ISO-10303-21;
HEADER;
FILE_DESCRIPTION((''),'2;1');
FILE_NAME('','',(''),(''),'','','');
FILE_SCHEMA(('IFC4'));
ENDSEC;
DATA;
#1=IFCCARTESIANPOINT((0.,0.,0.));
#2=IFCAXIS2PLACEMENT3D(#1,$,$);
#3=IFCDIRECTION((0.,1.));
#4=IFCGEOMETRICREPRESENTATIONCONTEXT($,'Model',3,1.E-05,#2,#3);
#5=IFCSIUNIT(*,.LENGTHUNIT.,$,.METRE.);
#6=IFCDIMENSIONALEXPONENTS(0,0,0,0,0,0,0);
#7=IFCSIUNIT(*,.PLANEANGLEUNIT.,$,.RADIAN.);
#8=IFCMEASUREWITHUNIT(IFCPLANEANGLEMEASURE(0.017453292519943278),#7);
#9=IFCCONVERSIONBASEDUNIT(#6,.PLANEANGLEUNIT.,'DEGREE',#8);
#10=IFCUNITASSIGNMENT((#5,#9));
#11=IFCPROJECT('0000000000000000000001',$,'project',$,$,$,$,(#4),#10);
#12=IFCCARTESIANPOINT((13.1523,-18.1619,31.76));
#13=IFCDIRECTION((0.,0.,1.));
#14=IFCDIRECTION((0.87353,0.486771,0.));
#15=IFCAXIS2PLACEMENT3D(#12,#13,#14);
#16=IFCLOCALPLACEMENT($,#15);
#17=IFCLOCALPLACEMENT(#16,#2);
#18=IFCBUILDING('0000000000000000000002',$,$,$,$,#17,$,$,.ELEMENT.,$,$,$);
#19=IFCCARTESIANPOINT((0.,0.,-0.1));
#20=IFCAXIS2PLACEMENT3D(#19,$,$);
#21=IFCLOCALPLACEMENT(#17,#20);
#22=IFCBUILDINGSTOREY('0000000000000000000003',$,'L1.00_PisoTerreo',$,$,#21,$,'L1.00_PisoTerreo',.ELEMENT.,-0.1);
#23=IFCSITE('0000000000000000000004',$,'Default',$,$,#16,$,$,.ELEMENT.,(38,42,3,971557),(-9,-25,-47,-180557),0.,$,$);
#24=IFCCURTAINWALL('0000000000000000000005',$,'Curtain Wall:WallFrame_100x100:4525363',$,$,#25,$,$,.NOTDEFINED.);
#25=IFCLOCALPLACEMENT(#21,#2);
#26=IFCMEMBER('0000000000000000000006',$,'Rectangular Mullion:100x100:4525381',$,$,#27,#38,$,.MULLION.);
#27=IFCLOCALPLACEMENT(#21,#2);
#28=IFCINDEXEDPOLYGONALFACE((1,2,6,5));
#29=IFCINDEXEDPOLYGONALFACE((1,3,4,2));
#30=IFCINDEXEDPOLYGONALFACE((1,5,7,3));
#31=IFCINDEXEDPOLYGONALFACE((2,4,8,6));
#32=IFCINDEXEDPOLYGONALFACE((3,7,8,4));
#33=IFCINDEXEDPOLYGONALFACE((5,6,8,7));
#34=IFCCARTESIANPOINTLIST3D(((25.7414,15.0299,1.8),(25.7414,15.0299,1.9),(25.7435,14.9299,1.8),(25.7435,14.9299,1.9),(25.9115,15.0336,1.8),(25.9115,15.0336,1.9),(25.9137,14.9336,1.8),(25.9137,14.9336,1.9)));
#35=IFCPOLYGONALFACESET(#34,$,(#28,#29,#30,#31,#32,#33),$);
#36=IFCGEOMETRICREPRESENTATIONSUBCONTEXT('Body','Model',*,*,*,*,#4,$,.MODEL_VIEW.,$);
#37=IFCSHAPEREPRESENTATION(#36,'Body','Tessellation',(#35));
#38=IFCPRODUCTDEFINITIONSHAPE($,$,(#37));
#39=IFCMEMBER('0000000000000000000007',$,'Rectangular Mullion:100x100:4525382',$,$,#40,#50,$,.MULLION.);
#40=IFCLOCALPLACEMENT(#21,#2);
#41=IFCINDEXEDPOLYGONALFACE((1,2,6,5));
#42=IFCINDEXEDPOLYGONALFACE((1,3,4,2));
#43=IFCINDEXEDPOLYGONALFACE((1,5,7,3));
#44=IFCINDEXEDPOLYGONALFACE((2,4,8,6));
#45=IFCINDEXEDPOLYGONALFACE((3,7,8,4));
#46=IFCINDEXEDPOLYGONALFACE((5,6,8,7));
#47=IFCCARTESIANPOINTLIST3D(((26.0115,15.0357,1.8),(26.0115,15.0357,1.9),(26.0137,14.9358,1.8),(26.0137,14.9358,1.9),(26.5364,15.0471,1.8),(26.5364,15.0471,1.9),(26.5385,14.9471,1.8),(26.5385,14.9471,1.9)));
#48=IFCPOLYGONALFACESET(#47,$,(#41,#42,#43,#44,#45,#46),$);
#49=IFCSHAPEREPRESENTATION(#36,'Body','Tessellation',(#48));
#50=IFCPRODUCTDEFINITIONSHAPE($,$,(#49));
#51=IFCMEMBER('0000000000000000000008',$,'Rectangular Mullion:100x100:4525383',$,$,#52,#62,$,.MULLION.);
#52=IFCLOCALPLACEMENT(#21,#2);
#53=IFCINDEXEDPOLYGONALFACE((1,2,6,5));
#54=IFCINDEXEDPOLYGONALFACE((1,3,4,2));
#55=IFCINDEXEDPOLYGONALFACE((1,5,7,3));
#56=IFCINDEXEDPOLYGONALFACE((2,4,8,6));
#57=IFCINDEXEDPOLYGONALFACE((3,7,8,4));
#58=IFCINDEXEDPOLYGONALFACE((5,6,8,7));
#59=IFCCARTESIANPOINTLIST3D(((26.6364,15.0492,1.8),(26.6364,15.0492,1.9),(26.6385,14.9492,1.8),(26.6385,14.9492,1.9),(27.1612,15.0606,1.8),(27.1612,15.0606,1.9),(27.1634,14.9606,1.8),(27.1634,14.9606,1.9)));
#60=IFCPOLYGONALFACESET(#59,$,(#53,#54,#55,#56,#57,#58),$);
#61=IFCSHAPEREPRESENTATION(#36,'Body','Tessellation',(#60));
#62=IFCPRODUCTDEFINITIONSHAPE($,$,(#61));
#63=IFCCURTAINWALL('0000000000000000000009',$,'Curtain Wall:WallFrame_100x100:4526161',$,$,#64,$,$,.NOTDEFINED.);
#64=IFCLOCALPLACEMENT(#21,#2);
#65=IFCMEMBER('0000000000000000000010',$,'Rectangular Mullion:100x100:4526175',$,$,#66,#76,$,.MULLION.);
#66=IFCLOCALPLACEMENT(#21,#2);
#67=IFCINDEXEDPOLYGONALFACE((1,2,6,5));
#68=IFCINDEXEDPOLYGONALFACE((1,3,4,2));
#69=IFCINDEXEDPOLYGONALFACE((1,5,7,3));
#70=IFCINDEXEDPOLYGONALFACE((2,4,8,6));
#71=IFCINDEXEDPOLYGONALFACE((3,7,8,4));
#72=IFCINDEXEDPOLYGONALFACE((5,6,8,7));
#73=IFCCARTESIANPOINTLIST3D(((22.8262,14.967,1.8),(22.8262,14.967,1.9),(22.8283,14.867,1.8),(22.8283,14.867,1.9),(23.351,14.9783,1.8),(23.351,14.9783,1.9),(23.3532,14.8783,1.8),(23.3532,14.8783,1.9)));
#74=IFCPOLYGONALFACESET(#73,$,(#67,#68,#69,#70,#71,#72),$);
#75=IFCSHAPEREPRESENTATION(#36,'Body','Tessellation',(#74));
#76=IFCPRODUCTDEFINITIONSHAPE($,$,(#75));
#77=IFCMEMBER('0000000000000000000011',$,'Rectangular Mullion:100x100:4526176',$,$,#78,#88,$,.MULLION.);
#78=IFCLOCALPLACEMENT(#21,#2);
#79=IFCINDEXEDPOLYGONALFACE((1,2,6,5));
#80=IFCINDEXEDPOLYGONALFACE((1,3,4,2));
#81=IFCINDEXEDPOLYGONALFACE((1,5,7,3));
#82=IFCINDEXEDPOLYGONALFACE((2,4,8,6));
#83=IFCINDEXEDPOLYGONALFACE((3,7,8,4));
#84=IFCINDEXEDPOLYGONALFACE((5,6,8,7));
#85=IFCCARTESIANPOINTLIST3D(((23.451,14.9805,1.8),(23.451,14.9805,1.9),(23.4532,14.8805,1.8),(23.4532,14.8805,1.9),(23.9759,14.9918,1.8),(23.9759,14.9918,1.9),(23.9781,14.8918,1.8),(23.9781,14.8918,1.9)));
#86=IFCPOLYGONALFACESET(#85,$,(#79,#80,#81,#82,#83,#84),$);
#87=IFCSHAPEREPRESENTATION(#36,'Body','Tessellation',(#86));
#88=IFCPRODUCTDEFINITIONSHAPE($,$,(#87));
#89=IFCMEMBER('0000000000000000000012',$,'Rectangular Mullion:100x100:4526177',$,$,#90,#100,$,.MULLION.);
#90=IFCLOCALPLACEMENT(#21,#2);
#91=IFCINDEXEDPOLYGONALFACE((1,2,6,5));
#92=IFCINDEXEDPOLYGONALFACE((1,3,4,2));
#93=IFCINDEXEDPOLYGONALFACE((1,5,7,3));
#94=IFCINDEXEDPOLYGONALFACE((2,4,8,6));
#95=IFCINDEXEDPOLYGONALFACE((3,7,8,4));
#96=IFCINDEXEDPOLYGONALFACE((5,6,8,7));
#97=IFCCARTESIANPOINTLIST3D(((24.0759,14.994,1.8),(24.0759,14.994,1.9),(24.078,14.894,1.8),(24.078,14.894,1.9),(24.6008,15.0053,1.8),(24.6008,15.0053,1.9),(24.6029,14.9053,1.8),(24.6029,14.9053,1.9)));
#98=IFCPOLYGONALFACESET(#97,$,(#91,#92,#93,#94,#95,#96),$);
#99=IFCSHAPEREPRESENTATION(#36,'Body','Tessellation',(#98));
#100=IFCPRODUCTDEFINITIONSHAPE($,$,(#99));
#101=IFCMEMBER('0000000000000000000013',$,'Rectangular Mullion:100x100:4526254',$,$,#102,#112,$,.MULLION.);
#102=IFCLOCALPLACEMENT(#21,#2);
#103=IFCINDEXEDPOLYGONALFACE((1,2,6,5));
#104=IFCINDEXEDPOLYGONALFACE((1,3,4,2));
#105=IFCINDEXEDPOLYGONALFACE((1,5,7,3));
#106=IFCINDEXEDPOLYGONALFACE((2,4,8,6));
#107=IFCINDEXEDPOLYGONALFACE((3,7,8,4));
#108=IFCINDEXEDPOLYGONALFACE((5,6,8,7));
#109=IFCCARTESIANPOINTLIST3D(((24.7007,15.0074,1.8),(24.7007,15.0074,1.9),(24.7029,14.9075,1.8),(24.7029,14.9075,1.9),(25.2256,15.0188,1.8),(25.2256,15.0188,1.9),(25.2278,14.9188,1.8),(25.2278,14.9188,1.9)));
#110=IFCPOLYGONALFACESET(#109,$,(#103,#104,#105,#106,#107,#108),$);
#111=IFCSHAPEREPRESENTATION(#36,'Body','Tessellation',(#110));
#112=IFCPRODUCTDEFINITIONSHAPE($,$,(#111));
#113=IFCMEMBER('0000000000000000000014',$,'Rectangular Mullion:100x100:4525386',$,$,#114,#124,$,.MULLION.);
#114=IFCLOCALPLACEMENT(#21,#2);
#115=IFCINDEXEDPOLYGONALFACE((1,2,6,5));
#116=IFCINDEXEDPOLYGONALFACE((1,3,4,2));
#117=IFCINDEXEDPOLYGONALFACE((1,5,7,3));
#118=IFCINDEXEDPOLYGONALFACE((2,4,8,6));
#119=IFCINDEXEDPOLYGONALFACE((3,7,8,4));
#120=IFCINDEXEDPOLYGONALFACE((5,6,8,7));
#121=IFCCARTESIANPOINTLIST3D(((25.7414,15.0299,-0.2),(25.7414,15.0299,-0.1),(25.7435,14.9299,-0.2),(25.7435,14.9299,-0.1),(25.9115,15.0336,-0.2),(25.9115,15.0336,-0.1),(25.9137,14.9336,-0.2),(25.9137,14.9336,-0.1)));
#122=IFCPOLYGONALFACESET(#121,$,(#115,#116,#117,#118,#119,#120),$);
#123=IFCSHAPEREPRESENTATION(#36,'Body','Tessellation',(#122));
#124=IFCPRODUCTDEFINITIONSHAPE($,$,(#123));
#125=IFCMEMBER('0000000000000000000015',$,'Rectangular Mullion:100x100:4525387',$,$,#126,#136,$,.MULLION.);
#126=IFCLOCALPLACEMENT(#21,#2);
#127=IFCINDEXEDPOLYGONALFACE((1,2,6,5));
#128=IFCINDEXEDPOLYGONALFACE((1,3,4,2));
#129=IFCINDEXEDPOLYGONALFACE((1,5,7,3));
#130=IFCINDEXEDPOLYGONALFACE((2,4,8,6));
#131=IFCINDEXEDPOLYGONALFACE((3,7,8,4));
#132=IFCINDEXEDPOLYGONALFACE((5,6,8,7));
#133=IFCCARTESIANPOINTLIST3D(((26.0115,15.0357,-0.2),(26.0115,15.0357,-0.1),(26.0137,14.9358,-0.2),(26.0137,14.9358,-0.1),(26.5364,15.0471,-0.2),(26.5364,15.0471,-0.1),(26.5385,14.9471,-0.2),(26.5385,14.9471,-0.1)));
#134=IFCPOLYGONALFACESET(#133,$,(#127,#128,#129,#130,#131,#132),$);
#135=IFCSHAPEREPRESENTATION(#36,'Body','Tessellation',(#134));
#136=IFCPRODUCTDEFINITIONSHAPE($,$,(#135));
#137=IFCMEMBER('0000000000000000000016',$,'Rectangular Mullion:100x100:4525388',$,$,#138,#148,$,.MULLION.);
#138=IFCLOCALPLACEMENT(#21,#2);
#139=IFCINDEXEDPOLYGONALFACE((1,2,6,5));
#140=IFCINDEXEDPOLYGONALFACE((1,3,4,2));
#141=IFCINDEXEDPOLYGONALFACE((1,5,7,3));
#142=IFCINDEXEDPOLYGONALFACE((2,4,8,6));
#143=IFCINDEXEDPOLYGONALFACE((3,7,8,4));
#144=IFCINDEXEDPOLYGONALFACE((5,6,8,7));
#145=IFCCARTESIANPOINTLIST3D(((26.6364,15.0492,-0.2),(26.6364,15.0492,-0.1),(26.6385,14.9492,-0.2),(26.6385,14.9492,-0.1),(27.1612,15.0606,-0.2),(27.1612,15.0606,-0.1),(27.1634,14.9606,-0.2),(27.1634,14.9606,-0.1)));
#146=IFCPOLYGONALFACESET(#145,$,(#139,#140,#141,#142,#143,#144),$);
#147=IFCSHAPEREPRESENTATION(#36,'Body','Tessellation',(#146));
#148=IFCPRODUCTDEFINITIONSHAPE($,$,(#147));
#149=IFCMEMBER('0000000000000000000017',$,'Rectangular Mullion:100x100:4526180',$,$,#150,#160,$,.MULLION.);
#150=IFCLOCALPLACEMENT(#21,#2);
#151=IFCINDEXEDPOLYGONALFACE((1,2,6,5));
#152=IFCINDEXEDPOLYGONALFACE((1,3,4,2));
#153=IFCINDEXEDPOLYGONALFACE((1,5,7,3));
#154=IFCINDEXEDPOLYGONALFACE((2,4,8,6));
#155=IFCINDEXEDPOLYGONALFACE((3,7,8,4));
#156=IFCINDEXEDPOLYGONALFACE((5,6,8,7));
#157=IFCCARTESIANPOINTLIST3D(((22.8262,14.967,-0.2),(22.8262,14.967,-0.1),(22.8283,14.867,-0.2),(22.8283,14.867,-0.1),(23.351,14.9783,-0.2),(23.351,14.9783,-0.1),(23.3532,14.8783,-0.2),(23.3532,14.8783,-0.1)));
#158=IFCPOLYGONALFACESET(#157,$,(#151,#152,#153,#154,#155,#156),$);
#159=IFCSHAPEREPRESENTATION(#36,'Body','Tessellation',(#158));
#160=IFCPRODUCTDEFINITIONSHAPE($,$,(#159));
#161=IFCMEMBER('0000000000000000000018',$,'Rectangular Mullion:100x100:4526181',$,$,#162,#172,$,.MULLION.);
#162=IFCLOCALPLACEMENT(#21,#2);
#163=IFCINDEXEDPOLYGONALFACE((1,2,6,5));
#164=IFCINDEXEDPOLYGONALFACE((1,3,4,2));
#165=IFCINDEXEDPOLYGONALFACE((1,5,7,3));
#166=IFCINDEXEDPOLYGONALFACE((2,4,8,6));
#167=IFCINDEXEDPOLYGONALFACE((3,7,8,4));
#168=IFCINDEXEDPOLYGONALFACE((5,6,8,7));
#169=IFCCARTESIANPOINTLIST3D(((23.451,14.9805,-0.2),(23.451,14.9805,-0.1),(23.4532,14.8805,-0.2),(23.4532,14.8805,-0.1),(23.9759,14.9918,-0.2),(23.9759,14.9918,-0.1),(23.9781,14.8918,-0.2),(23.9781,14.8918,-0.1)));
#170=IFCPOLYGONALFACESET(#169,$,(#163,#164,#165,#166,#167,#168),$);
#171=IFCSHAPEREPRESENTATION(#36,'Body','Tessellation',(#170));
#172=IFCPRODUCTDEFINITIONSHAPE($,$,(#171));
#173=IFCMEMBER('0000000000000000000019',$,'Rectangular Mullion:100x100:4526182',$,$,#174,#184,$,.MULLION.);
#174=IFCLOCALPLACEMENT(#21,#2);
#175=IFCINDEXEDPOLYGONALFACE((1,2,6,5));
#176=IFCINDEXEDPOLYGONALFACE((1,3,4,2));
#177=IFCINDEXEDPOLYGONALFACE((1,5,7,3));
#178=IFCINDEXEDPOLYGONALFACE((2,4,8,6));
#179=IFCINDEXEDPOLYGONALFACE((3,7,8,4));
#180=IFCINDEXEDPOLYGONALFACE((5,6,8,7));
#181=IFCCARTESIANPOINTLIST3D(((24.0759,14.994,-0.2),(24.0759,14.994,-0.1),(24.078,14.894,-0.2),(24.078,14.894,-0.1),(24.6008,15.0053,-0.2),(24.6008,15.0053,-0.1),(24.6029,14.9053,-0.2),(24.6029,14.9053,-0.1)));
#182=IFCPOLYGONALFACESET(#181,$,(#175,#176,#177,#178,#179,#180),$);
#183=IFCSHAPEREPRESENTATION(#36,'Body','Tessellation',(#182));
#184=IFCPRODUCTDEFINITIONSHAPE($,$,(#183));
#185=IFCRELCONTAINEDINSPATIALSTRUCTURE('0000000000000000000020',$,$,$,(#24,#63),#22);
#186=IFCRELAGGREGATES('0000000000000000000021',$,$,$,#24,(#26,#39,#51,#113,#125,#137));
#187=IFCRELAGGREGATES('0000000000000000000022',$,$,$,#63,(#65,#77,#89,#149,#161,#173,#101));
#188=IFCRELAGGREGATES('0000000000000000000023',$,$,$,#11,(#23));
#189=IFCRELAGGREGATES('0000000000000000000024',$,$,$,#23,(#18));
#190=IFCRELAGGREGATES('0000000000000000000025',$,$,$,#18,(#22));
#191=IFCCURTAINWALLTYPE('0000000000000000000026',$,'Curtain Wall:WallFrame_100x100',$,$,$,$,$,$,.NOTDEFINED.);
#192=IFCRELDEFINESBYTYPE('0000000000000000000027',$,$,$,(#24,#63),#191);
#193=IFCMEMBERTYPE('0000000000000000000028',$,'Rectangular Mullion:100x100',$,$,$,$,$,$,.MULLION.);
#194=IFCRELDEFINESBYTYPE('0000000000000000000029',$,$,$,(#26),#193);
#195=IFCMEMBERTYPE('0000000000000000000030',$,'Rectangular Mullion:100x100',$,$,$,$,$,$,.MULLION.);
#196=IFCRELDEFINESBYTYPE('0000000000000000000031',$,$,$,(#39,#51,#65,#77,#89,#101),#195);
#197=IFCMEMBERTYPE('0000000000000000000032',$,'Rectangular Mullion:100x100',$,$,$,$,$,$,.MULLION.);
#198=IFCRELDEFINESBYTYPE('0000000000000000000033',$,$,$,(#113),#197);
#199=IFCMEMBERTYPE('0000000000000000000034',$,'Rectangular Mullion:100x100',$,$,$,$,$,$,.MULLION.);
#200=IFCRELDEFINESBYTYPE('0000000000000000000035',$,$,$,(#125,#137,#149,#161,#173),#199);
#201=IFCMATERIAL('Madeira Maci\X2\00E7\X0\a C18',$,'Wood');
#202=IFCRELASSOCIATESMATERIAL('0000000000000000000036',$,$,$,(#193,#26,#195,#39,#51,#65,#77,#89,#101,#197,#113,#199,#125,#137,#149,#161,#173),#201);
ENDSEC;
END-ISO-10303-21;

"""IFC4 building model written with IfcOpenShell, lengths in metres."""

from ifc_helpers import new_model, entity, si_unit, converted_unit, direction, frame, origin, place, context, subcontext, project, spatial, indexed_curve, outline, extrude, source, transform, mapped, material, type_object, type_shapes, element, aggregate, save


model = new_model("IFC4")

# Units and contexts
model_context = context("Model", 3, precision=1e-05, world=origin(), true_north=direction((0.0, 1.0)))
body_context = subcontext(model_context, "Body", "Model", "MODEL_VIEW")
ifc_project = project(units=[si_unit("LENGTHUNIT", "METRE"), converted_unit("PLANEANGLEUNIT", "DEGREE", entity("IfcPlaneAngleMeasure", 0.017453292519943278), si_unit("PLANEANGLEUNIT", "RADIAN"), dimensions=[0, 0, 0, 0, 0, 0, 0])], contexts=[model_context])

# Site, building, storey
site_placement = place(None, frame((13.1523, -18.1619, 31.76), z_axis=(0.0, 0.0, 1.0), x_axis=(0.87353, 0.486771, 0.0)))
site = spatial("IfcSite", under=ifc_project, at=site_placement, Name="Default", CompositionType="ELEMENT", RefLatitude=(38, 42, 3, 971557), RefLongitude=(-9, -25, -47, -180557), RefElevation=0.0)
building_placement = place(site_placement, origin())
building = spatial("IfcBuilding", under=site, at=building_placement, CompositionType="ELEMENT")
storey_placement = place(building_placement, frame((0.0, 0.0, -0.1)))
storey = spatial("IfcBuildingStorey", under=building, at=storey_placement, Name="L1.00_PisoTerreo", LongName="L1.00_PisoTerreo", CompositionType="ELEMENT", Elevation=-0.1)

# Curtain walls, members
curtain_wall_type = type_object("IfcCurtainWallType", Name="Curtain Wall:WallFrame_100x100", PredefinedType="NOTDEFINED")
curtain_wall_1_placement = place(storey_placement, frame((0.0, 0.0, 0.1)))
curtain_wall_1 = element("IfcCurtainWall", 1, at=curtain_wall_1_placement, inside=storey, type_object=curtain_wall_type, Name="Curtain Wall:WallFrame_100x100:4525363", PredefinedType="NOTDEFINED")
ifc_material_1 = material(Name="Madeira Maciça C18", Category="Wood")
member_type_1 = type_object("IfcMemberType", Name="Rectangular Mullion:100x100", PredefinedType="MULLION", material=ifc_material_1)
shared_shape_1 = source(origin(), body_context, "Body", "SweptSolid", [
    extrude(outline(indexed_curve([(-0.05, -0.05), (0.05, -0.05), (0.05, 0.05), (-0.05, 0.05), (-0.05, -0.05)], self_intersect=False)), frame((-0.05, 0.0, -0.1702), z_axis=(0.0, 0.0, 1.0), x_axis=(-1.0, 0.0, 0.0)), (0.0, 0.0, 1.0), 0.1702),
])
type_shapes(member_type_1, [shared_shape_1])
member_1_placement = place(curtain_wall_1_placement, frame((25.9126, 14.9836, 1.8), z_axis=(0.999767, 0.021581, 0.0), x_axis=(0.0, 0.0, 1.0)))
member_1 = element("IfcMember", 2, at=member_1_placement, type_object=member_type_1, material=ifc_material_1, Name="Rectangular Mullion:100x100:4525381", PredefinedType="MULLION", context=body_context, shape_type="MappedRepresentation", body=[
    mapped(shared_shape_1, transform((0.0, 0.0, 0.0), scale=1.0)),
])
member_type_2 = type_object("IfcMemberType", Name="Rectangular Mullion:100x100", PredefinedType="MULLION", material=ifc_material_1)
shared_shape_2 = source(origin(), body_context, "Body", "SweptSolid", [
    extrude(outline(indexed_curve([(-0.05, -0.05), (0.05, -0.05), (0.05, 0.05), (-0.05, 0.05), (-0.05, -0.05)], self_intersect=False)), frame((-0.05, 0.0, -0.525), z_axis=(0.0, 0.0, 1.0), x_axis=(-1.0, 0.0, 0.0)), (0.0, 0.0, 1.0), 0.525),
])
type_shapes(member_type_2, [shared_shape_2])
member_2_placement = place(curtain_wall_1_placement, frame((26.5375, 14.9971, 1.8), z_axis=(0.999767, 0.021581, 0.0), x_axis=(0.0, 0.0, 1.0)))
member_2 = element("IfcMember", 3, at=member_2_placement, type_object=member_type_2, material=ifc_material_1, Name="Rectangular Mullion:100x100:4525382", PredefinedType="MULLION", context=body_context, shape_type="MappedRepresentation", body=[
    mapped(shared_shape_2, transform((0.0, 0.0, 0.0), scale=1.0)),
])
member_3_placement = place(curtain_wall_1_placement, frame((27.1623, 15.0106, 1.8), z_axis=(0.999767, 0.021581, 0.0), x_axis=(0.0, 0.0, 1.0)))
member_3 = element("IfcMember", 4, at=member_3_placement, type_object=member_type_2, material=ifc_material_1, Name="Rectangular Mullion:100x100:4525383", PredefinedType="MULLION", context=body_context, shape_type="MappedRepresentation", body=[
    mapped(shared_shape_2, transform((0.0, 0.0, 0.0), scale=1.0)),
])
curtain_wall_2_placement = place(storey_placement, frame((0.0, 0.0, 0.1)))
curtain_wall_2 = element("IfcCurtainWall", 5, at=curtain_wall_2_placement, inside=storey, type_object=curtain_wall_type, Name="Curtain Wall:WallFrame_100x100:4526161", PredefinedType="NOTDEFINED")
member_4_placement = place(curtain_wall_2_placement, frame((23.3521, 14.9283, 1.8), z_axis=(0.999767, 0.021581, 0.0), x_axis=(0.0, 0.0, 1.0)))
member_4 = element("IfcMember", 6, at=member_4_placement, type_object=member_type_2, material=ifc_material_1, Name="Rectangular Mullion:100x100:4526175", PredefinedType="MULLION", context=body_context, shape_type="MappedRepresentation", body=[
    mapped(shared_shape_2, transform((0.0, 0.0, 0.0), scale=1.0)),
])
member_5_placement = place(curtain_wall_2_placement, frame((23.977, 14.9418, 1.8), z_axis=(0.999767, 0.021581, 0.0), x_axis=(0.0, 0.0, 1.0)))
member_5 = element("IfcMember", 7, at=member_5_placement, type_object=member_type_2, material=ifc_material_1, Name="Rectangular Mullion:100x100:4526176", PredefinedType="MULLION", context=body_context, shape_type="MappedRepresentation", body=[
    mapped(shared_shape_2, transform((0.0, 0.0, 0.0), scale=1.0)),
])
member_6_placement = place(curtain_wall_2_placement, frame((24.6018, 14.9553, 1.8), z_axis=(0.999767, 0.021581, 0.0), x_axis=(0.0, 0.0, 1.0)))
member_6 = element("IfcMember", 8, at=member_6_placement, type_object=member_type_2, material=ifc_material_1, Name="Rectangular Mullion:100x100:4526177", PredefinedType="MULLION", context=body_context, shape_type="MappedRepresentation", body=[
    mapped(shared_shape_2, transform((0.0, 0.0, 0.0), scale=1.0)),
])
member_7_placement = place(curtain_wall_2_placement, frame((25.2267, 14.9688, 1.8), z_axis=(0.999767, 0.021581, 0.0), x_axis=(0.0, 0.0, 1.0)))
member_7 = element("IfcMember", 9, at=member_7_placement, type_object=member_type_2, material=ifc_material_1, Name="Rectangular Mullion:100x100:4526254", PredefinedType="MULLION", context=body_context, shape_type="MappedRepresentation", body=[
    mapped(shared_shape_2, transform((0.0, 0.0, 0.0), scale=1.0)),
])

# Members
member_type_3 = type_object("IfcMemberType", Name="Rectangular Mullion:100x100", PredefinedType="MULLION", material=ifc_material_1)
shared_shape_3 = source(origin(), body_context, "Body", "SweptSolid", [
    extrude(outline(indexed_curve([(-0.05, -0.05), (0.05, -0.05), (0.05, 0.05), (-0.05, 0.05), (-0.05, -0.05)], self_intersect=False)), frame((-0.05, 0.0, -0.1702), z_axis=(0.0, 0.0, 1.0), x_axis=(0.0, -1.0, 0.0)), (0.0, 0.0, 1.0), 0.1702),
])
type_shapes(member_type_3, [shared_shape_3])
member_8_placement = place(curtain_wall_1_placement, frame((25.7425, 14.9799, -0.3), z_axis=(-0.999767, -0.021581, 0.0), x_axis=(0.0, 0.0, -1.0)))
member_8 = element("IfcMember", 10, at=member_8_placement, type_object=member_type_3, material=ifc_material_1, Name="Rectangular Mullion:100x100:4525386", PredefinedType="MULLION", context=body_context, shape_type="MappedRepresentation", body=[
    mapped(shared_shape_3, transform((0.0, 0.0, 0.0), scale=1.0)),
])
member_type_4 = type_object("IfcMemberType", Name="Rectangular Mullion:100x100", PredefinedType="MULLION", material=ifc_material_1)
shared_shape_4 = source(origin(), body_context, "Body", "SweptSolid", [
    extrude(outline(indexed_curve([(-0.05, -0.05), (0.05, -0.05), (0.05, 0.05), (-0.05, 0.05), (-0.05, -0.05)], self_intersect=False)), frame((-0.05, 0.0, -0.525), z_axis=(0.0, 0.0, 1.0), x_axis=(0.0, -1.0, 0.0)), (0.0, 0.0, 1.0), 0.525),
])
type_shapes(member_type_4, [shared_shape_4])
member_9_placement = place(curtain_wall_1_placement, frame((26.0126, 14.9857, -0.3), z_axis=(-0.999767, -0.021581, 0.0), x_axis=(0.0, 0.0, -1.0)))
member_9 = element("IfcMember", 11, at=member_9_placement, type_object=member_type_4, material=ifc_material_1, Name="Rectangular Mullion:100x100:4525387", PredefinedType="MULLION", context=body_context, shape_type="MappedRepresentation", body=[
    mapped(shared_shape_4, transform((0.0, 0.0, 0.0), scale=1.0)),
])
member_10_placement = place(curtain_wall_1_placement, frame((26.6374, 14.9992, -0.3), z_axis=(-0.999767, -0.021581, 0.0), x_axis=(0.0, 0.0, -1.0)))
member_10 = element("IfcMember", 12, at=member_10_placement, type_object=member_type_4, material=ifc_material_1, Name="Rectangular Mullion:100x100:4525388", PredefinedType="MULLION", context=body_context, shape_type="MappedRepresentation", body=[
    mapped(shared_shape_4, transform((0.0, 0.0, 0.0), scale=1.0)),
])
member_11_placement = place(curtain_wall_2_placement, frame((22.8272, 14.917, -0.3), z_axis=(-0.999767, -0.021581, 0.0), x_axis=(0.0, 0.0, -1.0)))
member_11 = element("IfcMember", 13, at=member_11_placement, type_object=member_type_4, material=ifc_material_1, Name="Rectangular Mullion:100x100:4526180", PredefinedType="MULLION", context=body_context, shape_type="MappedRepresentation", body=[
    mapped(shared_shape_4, transform((0.0, 0.0, 0.0), scale=1.0)),
])
member_12_placement = place(curtain_wall_2_placement, frame((23.4521, 14.9305, -0.3), z_axis=(-0.999767, -0.021581, 0.0), x_axis=(0.0, 0.0, -1.0)))
member_12 = element("IfcMember", 14, at=member_12_placement, type_object=member_type_4, material=ifc_material_1, Name="Rectangular Mullion:100x100:4526181", PredefinedType="MULLION", context=body_context, shape_type="MappedRepresentation", body=[
    mapped(shared_shape_4, transform((0.0, 0.0, 0.0), scale=1.0)),
])
member_13_placement = place(curtain_wall_2_placement, frame((24.077, 14.944, -0.3), z_axis=(-0.999767, -0.021581, 0.0), x_axis=(0.0, 0.0, -1.0)))
member_13 = element("IfcMember", 15, at=member_13_placement, type_object=member_type_4, material=ifc_material_1, Name="Rectangular Mullion:100x100:4526182", PredefinedType="MULLION", context=body_context, shape_type="MappedRepresentation", body=[
    mapped(shared_shape_4, transform((0.0, 0.0, 0.0), scale=1.0)),
])
aggregate(curtain_wall_1, [member_1, member_2, member_3, member_8, member_9, member_10])
aggregate(curtain_wall_2, [member_4, member_5, member_6, member_11, member_12, member_13, member_7])

save(model, "model.ifc")
